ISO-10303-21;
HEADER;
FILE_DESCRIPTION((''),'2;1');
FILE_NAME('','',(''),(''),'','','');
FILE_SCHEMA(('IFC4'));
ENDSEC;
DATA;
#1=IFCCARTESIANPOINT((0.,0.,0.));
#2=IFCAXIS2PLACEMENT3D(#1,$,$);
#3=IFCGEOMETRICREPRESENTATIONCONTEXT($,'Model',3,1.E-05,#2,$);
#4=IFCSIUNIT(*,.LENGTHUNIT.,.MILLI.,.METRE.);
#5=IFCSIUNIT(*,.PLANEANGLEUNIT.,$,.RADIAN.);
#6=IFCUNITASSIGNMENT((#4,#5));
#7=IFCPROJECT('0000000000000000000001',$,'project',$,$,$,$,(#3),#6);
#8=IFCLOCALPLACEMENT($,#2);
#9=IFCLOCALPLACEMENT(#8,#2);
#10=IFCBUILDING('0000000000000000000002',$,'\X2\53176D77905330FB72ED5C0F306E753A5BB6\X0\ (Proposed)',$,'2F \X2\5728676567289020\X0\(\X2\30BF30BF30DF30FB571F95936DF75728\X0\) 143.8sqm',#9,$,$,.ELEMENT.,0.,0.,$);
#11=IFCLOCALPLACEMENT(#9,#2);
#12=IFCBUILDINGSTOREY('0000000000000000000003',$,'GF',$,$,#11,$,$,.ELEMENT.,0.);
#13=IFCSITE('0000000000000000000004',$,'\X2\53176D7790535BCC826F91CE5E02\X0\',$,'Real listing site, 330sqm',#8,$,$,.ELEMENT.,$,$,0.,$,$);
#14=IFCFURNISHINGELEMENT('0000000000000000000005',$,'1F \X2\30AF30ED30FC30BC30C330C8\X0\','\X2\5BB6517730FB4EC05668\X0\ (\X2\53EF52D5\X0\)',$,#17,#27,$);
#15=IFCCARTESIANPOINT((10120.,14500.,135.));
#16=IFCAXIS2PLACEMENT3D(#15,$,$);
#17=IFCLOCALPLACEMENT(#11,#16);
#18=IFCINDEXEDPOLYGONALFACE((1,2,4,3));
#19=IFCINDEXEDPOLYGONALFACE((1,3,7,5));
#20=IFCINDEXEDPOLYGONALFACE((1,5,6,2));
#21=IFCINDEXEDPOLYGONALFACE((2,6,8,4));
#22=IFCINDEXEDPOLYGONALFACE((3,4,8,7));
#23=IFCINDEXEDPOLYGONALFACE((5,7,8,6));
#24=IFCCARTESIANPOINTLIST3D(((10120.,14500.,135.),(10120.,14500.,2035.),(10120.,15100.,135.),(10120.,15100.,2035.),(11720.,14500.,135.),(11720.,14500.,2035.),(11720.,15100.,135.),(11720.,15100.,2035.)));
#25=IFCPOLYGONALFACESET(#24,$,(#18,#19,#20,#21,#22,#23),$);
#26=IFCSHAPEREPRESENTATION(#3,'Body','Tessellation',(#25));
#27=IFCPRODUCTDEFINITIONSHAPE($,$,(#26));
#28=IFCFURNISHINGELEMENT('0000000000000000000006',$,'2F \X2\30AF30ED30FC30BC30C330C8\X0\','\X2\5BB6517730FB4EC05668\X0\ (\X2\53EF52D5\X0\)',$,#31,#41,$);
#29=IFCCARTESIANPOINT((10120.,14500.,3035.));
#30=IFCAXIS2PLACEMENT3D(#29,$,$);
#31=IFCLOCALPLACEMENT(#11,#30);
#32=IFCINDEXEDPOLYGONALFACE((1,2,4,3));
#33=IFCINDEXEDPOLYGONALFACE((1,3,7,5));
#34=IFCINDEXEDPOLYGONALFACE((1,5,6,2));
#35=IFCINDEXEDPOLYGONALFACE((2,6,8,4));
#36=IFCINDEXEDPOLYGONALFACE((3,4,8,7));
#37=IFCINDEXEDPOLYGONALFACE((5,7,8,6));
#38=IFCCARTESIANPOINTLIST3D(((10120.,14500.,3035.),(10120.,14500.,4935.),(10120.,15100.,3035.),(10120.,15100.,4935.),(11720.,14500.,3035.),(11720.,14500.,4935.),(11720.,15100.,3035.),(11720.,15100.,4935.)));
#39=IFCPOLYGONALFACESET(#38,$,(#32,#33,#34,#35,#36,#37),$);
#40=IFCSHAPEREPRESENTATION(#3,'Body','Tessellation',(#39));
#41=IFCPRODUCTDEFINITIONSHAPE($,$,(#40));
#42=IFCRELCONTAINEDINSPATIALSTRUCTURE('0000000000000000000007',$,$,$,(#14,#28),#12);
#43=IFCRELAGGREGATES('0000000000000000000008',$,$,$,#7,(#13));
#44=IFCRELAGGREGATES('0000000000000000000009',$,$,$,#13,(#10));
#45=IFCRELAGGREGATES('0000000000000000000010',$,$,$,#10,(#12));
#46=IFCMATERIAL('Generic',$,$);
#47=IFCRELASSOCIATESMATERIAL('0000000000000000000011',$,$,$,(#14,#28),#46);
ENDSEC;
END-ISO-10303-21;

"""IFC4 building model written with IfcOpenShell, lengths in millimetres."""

from ifc_helpers import new_model, si_unit, frame, frame_2d, origin, place, context, project, spatial, rectangle, extrude, material, element, save


model = new_model("IFC4")

# Units and contexts
model_context = context("Model", 3, precision=1e-05, world=origin())
ifc_project = project(units=[si_unit("LENGTHUNIT", "METRE", prefix="MILLI"), si_unit("PLANEANGLEUNIT", "RADIAN")], contexts=[model_context])

# Site, building, storey
site_placement = place(None, origin())
site = spatial("IfcSite", under=ifc_project, at=site_placement, Name="北海道富良野市", ObjectType="Real listing site, 330sqm", CompositionType="ELEMENT", RefElevation=0.0)
building_placement = place(site_placement, origin())
building = spatial("IfcBuilding", under=site, at=building_placement, Name="北海道・狭小の町家 (Proposed)", ObjectType="2F 在来木造(タタミ・土間混在) 143.8sqm", CompositionType="ELEMENT", ElevationOfRefHeight=0.0, ElevationOfTerrain=0.0)
storey_placement = place(building_placement, origin())
storey = spatial("IfcBuildingStorey", under=building, at=storey_placement, Name="GF", CompositionType="ELEMENT", Elevation=0.0)

# Shared definitions
ifc_material_1 = material(Name="Generic")

# Furnishing elements
furnishing_1_placement = place(storey_placement, frame((10120.0, 14500.0, 135.0)))
element("IfcFurnishingElement", 1, at=furnishing_1_placement, inside=storey, material=ifc_material_1, Name="1F クローゼット", Description="家具・什器 (可動)", context=model_context, shape_type="SweptSolid", body=[
    extrude(rectangle(XDim=1600.0, YDim=600.0, at=frame_2d((800.0, 300.0))), frame((10120.0, 14500.0, 135.0)), (0.0, 0.0, 1.0), 1900.0),
])
furnishing_2_placement = place(storey_placement, frame((10120.0, 14500.0, 3035.0)))
element("IfcFurnishingElement", 2, at=furnishing_2_placement, inside=storey, material=ifc_material_1, Name="2F クローゼット", Description="家具・什器 (可動)", context=model_context, shape_type="SweptSolid", body=[
    extrude(rectangle(XDim=1600.0, YDim=600.0, at=frame_2d((800.0, 300.0))), frame((10120.0, 14500.0, 3035.0)), (0.0, 0.0, 1.0), 1900.0),
])

save(model, "model.ifc")
